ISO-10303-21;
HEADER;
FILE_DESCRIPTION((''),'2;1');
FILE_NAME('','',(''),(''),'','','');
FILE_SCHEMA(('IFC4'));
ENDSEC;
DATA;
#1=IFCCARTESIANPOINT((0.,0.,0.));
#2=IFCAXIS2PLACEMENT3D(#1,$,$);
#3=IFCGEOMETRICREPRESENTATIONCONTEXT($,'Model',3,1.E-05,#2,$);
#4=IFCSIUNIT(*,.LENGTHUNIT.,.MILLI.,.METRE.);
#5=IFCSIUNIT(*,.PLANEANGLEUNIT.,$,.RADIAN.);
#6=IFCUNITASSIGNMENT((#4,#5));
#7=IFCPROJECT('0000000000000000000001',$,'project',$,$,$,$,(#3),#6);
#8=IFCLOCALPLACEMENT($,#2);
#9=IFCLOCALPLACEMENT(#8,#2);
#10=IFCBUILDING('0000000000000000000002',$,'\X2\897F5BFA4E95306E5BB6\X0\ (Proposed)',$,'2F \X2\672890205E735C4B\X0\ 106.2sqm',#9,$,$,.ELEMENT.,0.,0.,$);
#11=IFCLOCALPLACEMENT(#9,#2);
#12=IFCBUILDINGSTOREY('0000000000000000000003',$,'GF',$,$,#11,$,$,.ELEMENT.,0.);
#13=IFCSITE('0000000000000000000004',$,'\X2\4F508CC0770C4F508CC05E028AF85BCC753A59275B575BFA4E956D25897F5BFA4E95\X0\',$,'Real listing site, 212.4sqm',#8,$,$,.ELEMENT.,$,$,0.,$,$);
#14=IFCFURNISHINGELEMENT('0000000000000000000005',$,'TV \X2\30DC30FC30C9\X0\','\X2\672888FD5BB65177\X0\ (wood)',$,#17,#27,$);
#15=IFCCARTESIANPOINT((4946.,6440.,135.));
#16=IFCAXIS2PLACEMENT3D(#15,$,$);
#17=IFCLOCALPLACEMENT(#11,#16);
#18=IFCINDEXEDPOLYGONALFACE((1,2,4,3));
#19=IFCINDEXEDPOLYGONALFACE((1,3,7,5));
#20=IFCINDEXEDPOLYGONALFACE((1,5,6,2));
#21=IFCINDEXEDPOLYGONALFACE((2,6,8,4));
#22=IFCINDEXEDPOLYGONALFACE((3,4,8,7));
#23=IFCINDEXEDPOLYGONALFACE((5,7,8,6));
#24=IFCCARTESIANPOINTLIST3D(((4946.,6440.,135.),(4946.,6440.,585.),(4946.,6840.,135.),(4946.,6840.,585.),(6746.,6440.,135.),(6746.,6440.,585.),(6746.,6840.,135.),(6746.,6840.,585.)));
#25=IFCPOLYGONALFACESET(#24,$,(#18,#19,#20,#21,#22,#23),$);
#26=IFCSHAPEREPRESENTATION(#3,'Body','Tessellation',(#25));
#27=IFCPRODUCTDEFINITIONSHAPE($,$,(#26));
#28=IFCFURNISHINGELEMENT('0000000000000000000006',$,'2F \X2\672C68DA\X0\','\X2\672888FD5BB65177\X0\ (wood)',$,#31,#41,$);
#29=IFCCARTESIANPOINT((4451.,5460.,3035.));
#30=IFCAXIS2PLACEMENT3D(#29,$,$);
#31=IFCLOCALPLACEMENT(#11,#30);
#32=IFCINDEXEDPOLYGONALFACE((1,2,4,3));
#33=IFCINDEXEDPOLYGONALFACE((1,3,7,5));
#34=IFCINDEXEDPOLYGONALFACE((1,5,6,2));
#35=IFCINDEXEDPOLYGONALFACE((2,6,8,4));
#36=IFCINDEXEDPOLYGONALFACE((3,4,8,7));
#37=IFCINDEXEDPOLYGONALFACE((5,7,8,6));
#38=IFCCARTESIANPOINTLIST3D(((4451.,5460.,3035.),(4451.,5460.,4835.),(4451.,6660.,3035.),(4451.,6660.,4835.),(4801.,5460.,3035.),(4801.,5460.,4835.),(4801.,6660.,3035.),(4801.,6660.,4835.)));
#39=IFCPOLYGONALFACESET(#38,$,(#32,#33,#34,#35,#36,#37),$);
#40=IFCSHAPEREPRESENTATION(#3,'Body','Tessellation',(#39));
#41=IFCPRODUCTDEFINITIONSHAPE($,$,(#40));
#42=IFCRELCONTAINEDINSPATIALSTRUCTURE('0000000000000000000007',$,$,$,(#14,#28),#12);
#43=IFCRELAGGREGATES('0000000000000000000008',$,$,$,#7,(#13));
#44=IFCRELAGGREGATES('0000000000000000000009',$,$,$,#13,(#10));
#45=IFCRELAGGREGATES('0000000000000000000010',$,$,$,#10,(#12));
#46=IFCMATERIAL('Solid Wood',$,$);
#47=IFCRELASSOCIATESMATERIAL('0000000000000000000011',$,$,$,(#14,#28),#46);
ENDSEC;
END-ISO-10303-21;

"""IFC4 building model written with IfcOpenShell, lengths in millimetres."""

from ifc_helpers import new_model, si_unit, frame, frame_2d, origin, place, context, project, spatial, rectangle, extrude, material, element, save


model = new_model("IFC4")

# Units and contexts
model_context = context("Model", 3, precision=1e-05, world=origin())
ifc_project = project(units=[si_unit("LENGTHUNIT", "METRE", prefix="MILLI"), si_unit("PLANEANGLEUNIT", "RADIAN")], contexts=[model_context])

# Site, building, storey
site_placement = place(None, origin())
site = spatial("IfcSite", under=ifc_project, at=site_placement, Name="佐賀県佐賀市諸富町大字寺井津西寺井", ObjectType="Real listing site, 212.4sqm", CompositionType="ELEMENT", RefElevation=0.0)
building_placement = place(site_placement, origin())
building = spatial("IfcBuilding", under=site, at=building_placement, Name="西寺井の家 (Proposed)", ObjectType="2F 木造平屋 106.2sqm", CompositionType="ELEMENT", ElevationOfRefHeight=0.0, ElevationOfTerrain=0.0)
storey_placement = place(building_placement, origin())
storey = spatial("IfcBuildingStorey", under=building, at=storey_placement, Name="GF", CompositionType="ELEMENT", Elevation=0.0)

# Shared definitions
ifc_material_1 = material(Name="Solid Wood")

# Furnishing elements
furnishing_1_placement = place(storey_placement, frame((4946.0, 6440.0, 135.0)))
element("IfcFurnishingElement", 1, at=furnishing_1_placement, inside=storey, material=ifc_material_1, Name="TV ボード", Description="木製家具 (wood)", context=model_context, shape_type="SweptSolid", body=[
    extrude(rectangle(XDim=1800.0, YDim=400.0, at=frame_2d((900.0, 200.0))), frame((4946.0, 6440.0, 135.0)), (0.0, 0.0, 1.0), 450.0),
])
furnishing_2_placement = place(storey_placement, frame((4451.0, 5460.0, 3035.0)))
element("IfcFurnishingElement", 2, at=furnishing_2_placement, inside=storey, material=ifc_material_1, Name="2F 本棚", Description="木製家具 (wood)", context=model_context, shape_type="SweptSolid", body=[
    extrude(rectangle(XDim=350.0, YDim=1200.0, at=frame_2d((175.0, 600.0))), frame((4451.0, 5460.0, 3035.0)), (0.0, 0.0, 1.0), 1800.0),
])

save(model, "model.ifc")
